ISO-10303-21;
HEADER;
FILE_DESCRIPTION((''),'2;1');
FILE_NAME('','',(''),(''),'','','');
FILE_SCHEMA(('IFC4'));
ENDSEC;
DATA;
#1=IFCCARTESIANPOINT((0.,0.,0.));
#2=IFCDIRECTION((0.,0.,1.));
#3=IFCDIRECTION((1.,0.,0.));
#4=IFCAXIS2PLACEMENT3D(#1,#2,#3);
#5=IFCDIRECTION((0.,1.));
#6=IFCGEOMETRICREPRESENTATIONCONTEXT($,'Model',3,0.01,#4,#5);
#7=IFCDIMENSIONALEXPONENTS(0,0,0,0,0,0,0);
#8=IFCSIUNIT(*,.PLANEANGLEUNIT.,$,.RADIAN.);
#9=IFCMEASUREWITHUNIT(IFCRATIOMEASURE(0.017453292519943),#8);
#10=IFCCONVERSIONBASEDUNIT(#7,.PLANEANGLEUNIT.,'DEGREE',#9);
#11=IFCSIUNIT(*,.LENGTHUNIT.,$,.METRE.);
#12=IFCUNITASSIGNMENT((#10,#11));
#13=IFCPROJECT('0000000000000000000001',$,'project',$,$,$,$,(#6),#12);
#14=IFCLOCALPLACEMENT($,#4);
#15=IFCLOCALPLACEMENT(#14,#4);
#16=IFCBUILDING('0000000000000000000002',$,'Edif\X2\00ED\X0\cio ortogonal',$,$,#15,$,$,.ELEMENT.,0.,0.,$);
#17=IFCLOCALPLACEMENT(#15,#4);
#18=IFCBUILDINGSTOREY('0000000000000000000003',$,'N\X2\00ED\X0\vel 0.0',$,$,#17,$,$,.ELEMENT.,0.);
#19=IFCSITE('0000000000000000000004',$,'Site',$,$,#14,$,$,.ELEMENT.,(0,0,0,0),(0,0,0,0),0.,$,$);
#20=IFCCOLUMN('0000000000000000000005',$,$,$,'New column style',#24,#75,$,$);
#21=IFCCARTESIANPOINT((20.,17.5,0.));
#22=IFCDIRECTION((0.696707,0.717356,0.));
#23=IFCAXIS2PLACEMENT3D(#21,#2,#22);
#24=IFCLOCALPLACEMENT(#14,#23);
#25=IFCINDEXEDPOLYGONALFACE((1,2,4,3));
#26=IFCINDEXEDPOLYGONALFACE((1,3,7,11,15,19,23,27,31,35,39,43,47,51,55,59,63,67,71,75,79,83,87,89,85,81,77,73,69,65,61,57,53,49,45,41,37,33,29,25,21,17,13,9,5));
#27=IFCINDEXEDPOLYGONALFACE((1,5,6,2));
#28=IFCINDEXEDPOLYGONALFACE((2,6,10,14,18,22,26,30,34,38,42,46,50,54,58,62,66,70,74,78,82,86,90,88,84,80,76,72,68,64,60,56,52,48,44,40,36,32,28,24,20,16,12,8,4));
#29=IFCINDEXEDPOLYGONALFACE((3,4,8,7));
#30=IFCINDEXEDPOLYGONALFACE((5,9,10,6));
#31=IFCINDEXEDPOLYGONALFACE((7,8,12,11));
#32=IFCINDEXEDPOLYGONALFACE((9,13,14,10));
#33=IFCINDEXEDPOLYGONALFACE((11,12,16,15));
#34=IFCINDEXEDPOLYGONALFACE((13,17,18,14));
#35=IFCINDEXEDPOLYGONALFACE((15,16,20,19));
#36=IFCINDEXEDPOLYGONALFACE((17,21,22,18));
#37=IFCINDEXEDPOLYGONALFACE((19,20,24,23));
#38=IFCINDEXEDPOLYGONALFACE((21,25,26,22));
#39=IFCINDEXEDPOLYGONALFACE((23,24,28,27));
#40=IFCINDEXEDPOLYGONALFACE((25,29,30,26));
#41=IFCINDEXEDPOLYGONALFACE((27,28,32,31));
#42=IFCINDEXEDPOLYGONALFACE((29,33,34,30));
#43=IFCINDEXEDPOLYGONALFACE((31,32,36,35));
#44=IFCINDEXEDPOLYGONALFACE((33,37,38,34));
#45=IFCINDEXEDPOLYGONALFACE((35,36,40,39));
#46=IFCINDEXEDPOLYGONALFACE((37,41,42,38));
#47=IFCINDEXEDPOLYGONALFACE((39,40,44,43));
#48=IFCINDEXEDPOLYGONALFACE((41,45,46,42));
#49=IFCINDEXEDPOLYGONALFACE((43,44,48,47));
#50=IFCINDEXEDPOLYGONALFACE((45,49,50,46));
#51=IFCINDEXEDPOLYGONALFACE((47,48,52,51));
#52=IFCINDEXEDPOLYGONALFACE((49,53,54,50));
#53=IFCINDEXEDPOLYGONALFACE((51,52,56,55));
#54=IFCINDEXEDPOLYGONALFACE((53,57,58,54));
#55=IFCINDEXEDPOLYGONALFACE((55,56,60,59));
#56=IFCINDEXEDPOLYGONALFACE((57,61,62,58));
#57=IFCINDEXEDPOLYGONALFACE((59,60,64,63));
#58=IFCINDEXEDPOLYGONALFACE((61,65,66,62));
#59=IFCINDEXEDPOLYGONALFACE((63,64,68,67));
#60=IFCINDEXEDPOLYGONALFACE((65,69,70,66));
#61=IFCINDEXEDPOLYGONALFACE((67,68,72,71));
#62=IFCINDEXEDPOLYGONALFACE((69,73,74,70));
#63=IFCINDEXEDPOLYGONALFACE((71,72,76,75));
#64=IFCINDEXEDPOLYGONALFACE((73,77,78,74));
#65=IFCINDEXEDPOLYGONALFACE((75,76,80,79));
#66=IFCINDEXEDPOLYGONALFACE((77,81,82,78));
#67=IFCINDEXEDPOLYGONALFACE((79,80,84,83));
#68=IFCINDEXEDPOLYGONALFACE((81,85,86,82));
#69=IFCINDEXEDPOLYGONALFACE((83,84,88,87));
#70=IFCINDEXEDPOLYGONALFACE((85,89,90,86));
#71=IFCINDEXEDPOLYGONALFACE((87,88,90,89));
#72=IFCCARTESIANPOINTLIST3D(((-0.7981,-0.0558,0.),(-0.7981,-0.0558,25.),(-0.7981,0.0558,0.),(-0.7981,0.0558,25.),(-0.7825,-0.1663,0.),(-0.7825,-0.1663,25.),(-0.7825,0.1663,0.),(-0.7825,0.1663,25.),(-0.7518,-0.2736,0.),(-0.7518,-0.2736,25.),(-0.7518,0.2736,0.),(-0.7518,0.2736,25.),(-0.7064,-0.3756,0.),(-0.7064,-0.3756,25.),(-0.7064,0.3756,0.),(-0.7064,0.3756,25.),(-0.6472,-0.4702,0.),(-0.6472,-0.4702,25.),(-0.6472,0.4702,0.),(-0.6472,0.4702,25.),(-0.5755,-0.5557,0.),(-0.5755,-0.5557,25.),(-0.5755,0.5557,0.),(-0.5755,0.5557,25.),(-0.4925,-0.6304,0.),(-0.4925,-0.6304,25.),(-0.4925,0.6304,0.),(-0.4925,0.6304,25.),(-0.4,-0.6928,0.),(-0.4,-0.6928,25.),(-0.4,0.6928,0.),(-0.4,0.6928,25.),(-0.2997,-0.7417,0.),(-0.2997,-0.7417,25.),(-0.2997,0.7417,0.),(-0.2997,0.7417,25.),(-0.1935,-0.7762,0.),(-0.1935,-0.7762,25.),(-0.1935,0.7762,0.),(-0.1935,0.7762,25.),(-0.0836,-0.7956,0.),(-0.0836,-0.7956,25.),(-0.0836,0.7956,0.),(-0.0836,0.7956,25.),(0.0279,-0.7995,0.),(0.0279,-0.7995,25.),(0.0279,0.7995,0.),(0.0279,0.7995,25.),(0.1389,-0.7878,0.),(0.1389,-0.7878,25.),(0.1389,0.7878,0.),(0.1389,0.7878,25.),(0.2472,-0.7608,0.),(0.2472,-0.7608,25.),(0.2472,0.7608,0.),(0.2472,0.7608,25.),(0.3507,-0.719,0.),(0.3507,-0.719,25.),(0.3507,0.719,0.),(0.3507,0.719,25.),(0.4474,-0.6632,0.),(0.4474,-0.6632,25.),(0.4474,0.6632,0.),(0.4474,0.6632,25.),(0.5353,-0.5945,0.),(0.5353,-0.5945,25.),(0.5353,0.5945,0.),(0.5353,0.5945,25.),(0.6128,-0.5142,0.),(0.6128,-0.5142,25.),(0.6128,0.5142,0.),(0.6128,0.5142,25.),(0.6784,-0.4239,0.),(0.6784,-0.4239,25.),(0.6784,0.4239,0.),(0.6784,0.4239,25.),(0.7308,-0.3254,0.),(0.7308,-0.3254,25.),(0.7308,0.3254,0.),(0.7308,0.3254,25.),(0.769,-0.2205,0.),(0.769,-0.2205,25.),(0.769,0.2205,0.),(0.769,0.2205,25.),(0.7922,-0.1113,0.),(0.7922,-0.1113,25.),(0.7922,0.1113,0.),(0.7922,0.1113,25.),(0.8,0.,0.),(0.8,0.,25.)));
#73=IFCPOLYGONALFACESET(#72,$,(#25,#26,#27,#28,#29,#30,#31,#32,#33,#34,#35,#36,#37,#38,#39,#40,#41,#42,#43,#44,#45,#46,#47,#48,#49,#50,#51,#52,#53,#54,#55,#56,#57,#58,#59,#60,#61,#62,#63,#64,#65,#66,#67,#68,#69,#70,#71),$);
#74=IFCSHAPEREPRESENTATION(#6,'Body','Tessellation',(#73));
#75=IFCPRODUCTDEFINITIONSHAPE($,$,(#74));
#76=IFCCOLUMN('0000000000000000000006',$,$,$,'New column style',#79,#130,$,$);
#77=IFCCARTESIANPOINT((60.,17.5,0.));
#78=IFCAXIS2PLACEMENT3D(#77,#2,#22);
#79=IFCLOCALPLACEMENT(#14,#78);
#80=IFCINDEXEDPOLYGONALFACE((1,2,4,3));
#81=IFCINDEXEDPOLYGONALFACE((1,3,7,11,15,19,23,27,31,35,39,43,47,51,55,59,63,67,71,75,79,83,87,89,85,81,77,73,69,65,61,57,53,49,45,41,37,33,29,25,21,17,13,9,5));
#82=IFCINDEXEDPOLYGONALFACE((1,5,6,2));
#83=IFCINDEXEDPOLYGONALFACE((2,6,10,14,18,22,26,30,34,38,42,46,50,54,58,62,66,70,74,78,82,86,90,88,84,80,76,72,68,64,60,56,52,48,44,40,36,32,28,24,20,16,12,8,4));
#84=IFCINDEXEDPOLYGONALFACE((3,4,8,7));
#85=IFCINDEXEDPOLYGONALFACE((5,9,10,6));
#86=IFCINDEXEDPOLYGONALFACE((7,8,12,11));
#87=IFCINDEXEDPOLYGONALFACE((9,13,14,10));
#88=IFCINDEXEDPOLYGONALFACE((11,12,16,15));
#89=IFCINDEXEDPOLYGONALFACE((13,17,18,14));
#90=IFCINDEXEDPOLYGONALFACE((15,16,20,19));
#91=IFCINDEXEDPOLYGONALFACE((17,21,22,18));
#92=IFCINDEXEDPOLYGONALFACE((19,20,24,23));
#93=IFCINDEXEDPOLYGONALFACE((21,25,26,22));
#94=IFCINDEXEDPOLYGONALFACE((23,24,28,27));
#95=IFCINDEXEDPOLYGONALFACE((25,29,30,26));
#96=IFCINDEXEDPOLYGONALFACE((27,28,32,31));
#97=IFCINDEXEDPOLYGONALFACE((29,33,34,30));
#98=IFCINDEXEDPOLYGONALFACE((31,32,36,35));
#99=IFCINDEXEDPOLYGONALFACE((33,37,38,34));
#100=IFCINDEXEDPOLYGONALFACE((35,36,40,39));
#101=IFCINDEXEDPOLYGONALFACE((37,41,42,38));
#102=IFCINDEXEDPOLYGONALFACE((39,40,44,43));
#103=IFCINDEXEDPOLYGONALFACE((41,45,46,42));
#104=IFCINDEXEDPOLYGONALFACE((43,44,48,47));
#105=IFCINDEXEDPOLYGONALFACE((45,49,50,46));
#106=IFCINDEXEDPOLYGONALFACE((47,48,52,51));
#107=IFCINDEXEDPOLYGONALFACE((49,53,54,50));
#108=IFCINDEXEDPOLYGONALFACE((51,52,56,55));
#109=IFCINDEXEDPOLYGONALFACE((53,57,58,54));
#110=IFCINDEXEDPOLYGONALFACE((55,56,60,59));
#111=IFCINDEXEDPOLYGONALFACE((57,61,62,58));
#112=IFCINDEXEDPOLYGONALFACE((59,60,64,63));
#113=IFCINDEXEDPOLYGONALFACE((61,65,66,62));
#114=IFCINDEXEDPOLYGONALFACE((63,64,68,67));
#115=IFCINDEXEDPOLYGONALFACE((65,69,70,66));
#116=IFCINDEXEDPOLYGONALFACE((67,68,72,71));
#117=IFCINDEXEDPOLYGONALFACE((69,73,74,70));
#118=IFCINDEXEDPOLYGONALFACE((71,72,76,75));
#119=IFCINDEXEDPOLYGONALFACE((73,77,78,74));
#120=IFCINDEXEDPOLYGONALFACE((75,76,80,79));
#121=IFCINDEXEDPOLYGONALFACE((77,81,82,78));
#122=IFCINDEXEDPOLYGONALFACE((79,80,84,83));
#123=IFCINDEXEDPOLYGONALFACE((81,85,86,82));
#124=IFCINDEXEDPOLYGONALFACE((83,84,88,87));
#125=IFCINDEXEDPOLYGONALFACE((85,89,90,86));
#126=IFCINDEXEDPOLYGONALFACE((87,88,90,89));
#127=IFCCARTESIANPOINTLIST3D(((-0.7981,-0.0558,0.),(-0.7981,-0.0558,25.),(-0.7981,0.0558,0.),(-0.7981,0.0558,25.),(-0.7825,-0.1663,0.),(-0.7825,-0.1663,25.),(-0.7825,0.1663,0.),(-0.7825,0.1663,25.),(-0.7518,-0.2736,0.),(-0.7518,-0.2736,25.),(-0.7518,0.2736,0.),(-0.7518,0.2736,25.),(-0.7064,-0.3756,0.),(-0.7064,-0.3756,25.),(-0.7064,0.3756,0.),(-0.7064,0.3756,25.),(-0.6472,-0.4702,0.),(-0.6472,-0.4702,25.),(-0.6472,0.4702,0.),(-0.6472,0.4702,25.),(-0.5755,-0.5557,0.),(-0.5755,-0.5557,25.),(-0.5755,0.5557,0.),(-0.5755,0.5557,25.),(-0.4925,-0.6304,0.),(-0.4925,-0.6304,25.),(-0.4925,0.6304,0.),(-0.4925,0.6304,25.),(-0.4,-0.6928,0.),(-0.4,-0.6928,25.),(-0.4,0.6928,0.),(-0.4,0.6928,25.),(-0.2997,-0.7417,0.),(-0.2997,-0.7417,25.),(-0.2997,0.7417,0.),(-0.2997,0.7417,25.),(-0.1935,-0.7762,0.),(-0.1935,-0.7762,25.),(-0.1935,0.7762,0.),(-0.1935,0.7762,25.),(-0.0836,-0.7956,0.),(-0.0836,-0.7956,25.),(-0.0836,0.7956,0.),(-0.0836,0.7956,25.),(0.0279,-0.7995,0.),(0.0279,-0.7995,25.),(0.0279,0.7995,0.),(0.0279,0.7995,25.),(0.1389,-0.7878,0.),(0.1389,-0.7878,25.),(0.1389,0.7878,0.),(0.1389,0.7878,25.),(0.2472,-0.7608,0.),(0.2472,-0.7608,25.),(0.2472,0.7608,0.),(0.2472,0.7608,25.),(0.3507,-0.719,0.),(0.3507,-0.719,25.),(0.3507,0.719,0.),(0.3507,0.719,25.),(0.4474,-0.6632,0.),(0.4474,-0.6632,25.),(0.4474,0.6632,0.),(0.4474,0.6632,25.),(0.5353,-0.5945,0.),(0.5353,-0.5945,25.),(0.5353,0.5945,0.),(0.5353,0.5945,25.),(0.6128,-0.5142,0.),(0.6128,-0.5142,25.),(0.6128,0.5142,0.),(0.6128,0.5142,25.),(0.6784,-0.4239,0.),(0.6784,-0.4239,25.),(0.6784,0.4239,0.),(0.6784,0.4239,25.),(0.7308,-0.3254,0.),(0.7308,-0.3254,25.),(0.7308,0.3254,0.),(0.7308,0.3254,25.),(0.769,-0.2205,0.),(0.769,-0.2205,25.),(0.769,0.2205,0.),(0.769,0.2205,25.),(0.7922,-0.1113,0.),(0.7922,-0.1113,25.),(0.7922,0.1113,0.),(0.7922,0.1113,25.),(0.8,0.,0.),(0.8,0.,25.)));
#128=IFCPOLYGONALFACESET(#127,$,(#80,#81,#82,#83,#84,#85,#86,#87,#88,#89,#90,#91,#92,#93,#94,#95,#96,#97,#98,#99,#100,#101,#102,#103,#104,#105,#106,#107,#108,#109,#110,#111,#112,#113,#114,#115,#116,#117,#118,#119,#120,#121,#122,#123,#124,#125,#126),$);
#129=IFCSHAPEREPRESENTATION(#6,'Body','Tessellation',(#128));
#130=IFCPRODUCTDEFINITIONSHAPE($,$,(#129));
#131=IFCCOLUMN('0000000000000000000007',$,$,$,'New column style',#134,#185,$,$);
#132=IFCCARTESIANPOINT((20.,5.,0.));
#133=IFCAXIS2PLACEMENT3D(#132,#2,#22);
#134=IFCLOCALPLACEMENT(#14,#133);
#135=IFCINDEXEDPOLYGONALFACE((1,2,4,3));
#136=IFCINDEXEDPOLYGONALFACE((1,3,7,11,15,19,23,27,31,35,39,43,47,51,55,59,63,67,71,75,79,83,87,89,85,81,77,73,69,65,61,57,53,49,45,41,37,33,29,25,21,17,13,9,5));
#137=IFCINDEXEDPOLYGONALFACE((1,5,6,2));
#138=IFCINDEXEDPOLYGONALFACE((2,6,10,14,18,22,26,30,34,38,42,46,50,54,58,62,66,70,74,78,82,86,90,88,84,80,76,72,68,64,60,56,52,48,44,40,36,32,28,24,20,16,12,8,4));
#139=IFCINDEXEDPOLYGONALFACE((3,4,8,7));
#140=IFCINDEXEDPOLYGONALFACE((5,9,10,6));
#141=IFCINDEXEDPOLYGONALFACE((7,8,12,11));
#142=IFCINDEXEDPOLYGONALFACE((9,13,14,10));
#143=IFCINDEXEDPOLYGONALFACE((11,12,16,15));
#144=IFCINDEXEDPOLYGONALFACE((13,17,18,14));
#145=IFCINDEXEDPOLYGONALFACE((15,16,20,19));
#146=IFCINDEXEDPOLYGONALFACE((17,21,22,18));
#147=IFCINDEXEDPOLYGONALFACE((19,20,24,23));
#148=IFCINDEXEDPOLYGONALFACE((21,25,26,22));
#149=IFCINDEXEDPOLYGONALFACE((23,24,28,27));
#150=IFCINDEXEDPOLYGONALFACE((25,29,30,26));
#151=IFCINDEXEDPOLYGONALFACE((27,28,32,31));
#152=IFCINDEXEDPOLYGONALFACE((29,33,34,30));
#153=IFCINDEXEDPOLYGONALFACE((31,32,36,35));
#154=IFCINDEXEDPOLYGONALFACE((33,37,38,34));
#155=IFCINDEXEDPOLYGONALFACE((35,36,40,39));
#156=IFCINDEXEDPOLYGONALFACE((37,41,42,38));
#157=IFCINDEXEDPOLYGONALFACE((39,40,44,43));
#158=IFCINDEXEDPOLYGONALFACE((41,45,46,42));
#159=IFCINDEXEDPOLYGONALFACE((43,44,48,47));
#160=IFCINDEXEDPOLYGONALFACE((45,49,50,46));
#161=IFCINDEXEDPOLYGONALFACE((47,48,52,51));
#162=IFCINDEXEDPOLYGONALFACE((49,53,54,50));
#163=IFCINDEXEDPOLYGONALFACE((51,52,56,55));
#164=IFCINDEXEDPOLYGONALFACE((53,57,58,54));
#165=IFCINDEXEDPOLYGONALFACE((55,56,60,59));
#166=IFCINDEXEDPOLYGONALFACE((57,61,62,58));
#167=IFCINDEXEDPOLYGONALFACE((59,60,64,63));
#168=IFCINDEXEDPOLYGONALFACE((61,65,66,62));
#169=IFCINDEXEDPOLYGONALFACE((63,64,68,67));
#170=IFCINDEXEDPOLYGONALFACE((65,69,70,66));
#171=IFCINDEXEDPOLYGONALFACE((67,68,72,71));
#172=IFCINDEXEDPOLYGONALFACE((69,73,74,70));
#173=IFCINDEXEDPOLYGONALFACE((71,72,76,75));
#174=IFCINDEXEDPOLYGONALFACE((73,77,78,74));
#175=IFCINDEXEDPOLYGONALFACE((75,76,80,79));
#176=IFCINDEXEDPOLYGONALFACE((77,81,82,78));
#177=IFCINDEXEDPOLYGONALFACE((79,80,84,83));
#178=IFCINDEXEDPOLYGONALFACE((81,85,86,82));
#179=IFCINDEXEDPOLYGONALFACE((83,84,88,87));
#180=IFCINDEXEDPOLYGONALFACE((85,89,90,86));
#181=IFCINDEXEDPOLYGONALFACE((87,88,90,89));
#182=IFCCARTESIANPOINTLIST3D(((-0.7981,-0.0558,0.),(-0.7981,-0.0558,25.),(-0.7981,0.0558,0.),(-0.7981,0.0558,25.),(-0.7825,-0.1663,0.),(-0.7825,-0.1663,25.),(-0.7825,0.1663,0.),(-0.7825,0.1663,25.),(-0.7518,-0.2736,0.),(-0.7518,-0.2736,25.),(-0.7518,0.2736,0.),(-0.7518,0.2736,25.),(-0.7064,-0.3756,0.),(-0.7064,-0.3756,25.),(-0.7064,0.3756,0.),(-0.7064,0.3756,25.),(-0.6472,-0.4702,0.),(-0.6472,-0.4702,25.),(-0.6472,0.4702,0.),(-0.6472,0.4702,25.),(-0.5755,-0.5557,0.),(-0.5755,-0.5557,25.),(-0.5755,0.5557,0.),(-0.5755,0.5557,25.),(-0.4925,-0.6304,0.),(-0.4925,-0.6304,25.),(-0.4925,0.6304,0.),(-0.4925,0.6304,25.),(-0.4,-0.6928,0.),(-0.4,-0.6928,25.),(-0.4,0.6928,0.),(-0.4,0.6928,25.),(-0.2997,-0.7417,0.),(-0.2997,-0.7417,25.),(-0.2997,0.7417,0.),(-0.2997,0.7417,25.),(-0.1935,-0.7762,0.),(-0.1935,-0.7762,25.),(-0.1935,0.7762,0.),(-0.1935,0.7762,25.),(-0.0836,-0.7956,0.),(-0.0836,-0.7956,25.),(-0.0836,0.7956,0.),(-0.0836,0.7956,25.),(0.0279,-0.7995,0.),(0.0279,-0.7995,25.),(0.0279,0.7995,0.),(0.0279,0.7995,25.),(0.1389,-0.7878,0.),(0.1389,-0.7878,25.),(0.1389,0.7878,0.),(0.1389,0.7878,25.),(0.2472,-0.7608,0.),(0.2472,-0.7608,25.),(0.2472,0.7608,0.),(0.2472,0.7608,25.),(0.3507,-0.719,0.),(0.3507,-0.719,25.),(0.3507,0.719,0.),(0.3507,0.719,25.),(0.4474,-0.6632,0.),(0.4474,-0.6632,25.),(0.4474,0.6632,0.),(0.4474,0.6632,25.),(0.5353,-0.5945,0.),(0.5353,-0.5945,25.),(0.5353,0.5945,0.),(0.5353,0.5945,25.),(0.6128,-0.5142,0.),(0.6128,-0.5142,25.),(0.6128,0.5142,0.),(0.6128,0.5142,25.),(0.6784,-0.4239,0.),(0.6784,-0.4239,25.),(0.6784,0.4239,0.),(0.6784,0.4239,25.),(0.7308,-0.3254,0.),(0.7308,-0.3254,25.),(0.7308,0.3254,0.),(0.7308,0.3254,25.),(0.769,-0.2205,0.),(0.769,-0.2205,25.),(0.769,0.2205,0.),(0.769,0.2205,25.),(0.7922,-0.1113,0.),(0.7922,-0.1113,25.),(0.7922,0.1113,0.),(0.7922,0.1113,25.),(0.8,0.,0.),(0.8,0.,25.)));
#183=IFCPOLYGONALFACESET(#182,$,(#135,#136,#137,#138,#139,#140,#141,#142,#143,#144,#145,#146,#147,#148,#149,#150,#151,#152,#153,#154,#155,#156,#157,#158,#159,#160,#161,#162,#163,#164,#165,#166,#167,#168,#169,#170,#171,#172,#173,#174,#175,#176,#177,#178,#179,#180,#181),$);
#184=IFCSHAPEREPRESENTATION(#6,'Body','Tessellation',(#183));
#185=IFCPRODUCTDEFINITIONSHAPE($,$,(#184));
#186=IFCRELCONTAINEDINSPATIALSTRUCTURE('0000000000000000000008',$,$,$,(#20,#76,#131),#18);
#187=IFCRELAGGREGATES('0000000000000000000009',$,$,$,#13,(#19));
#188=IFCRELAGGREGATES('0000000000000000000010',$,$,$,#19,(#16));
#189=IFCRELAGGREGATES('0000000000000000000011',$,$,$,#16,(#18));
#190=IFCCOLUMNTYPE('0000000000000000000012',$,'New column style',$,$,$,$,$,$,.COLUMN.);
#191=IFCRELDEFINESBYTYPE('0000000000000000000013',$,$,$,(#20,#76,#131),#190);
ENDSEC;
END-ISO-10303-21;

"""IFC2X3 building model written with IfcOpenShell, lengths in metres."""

from ifc_helpers import new_model, entity, si_unit, converted_unit, direction, frame, origin_with_axes, origin_2d, place, context, project, spatial, circle, extrude, type_object, element, save


model = new_model("IFC2X3")

# Units and contexts
model_context = context("Model", 3, precision=0.01, world=origin_with_axes(), true_north=direction((0.0, 1.0)))
ifc_project = project(units=[converted_unit("PLANEANGLEUNIT", "DEGREE", entity("IfcRatioMeasure", 0.017453292519943), si_unit("PLANEANGLEUNIT", "RADIAN"), dimensions=[0, 0, 0, 0, 0, 0, 0]), si_unit("LENGTHUNIT", "METRE")], contexts=[model_context])

# Site, building, storey
site_placement = place(None, origin_with_axes())
site = spatial("IfcSite", under=ifc_project, at=site_placement, Name="Site", CompositionType="ELEMENT", RefLatitude=(0, 0, 0, 0), RefLongitude=(0, 0, 0, 0), RefElevation=0.0)
building_placement = place(site_placement, origin_with_axes())
building = spatial("IfcBuilding", under=site, at=building_placement, Name="Edifício ortogonal", CompositionType="ELEMENT", ElevationOfRefHeight=0.0, ElevationOfTerrain=0.0)
storey_placement = place(building_placement, origin_with_axes())
storey = spatial("IfcBuildingStorey", under=building, at=storey_placement, Name="Nível 0.0", CompositionType="ELEMENT", Elevation=0.0)

# Columns
column_type = type_object("IfcColumnType", Name="New column style", PredefinedType="COLUMN")
for number, where, z_axis, x_axis in (
    (1, (20.0, 17.5, 0.0), (0.0, 0.0, 1.0), (0.696707, 0.717356, 0.0)),
    (2, (60.0, 17.5, 0.0), (0.0, 0.0, 1.0), (0.696707, 0.717356, 0.0)),
    (3, (20.0, 5.0, 0.0), (0.0, 0.0, 1.0), (0.696707, 0.717356, 0.0)),
):
    element("IfcColumn", number, at=place(site_placement, frame(where, z_axis=z_axis, x_axis=x_axis)), inside=storey, type_object=column_type, ObjectType="New column style", context=model_context, shape_type="SweptSolid", body=[
        extrude(circle(Radius=0.8, at=origin_2d()), origin_with_axes(), (0.0, 0.0, 1.0), 25.0),
    ])

save(model, "model.ifc")
